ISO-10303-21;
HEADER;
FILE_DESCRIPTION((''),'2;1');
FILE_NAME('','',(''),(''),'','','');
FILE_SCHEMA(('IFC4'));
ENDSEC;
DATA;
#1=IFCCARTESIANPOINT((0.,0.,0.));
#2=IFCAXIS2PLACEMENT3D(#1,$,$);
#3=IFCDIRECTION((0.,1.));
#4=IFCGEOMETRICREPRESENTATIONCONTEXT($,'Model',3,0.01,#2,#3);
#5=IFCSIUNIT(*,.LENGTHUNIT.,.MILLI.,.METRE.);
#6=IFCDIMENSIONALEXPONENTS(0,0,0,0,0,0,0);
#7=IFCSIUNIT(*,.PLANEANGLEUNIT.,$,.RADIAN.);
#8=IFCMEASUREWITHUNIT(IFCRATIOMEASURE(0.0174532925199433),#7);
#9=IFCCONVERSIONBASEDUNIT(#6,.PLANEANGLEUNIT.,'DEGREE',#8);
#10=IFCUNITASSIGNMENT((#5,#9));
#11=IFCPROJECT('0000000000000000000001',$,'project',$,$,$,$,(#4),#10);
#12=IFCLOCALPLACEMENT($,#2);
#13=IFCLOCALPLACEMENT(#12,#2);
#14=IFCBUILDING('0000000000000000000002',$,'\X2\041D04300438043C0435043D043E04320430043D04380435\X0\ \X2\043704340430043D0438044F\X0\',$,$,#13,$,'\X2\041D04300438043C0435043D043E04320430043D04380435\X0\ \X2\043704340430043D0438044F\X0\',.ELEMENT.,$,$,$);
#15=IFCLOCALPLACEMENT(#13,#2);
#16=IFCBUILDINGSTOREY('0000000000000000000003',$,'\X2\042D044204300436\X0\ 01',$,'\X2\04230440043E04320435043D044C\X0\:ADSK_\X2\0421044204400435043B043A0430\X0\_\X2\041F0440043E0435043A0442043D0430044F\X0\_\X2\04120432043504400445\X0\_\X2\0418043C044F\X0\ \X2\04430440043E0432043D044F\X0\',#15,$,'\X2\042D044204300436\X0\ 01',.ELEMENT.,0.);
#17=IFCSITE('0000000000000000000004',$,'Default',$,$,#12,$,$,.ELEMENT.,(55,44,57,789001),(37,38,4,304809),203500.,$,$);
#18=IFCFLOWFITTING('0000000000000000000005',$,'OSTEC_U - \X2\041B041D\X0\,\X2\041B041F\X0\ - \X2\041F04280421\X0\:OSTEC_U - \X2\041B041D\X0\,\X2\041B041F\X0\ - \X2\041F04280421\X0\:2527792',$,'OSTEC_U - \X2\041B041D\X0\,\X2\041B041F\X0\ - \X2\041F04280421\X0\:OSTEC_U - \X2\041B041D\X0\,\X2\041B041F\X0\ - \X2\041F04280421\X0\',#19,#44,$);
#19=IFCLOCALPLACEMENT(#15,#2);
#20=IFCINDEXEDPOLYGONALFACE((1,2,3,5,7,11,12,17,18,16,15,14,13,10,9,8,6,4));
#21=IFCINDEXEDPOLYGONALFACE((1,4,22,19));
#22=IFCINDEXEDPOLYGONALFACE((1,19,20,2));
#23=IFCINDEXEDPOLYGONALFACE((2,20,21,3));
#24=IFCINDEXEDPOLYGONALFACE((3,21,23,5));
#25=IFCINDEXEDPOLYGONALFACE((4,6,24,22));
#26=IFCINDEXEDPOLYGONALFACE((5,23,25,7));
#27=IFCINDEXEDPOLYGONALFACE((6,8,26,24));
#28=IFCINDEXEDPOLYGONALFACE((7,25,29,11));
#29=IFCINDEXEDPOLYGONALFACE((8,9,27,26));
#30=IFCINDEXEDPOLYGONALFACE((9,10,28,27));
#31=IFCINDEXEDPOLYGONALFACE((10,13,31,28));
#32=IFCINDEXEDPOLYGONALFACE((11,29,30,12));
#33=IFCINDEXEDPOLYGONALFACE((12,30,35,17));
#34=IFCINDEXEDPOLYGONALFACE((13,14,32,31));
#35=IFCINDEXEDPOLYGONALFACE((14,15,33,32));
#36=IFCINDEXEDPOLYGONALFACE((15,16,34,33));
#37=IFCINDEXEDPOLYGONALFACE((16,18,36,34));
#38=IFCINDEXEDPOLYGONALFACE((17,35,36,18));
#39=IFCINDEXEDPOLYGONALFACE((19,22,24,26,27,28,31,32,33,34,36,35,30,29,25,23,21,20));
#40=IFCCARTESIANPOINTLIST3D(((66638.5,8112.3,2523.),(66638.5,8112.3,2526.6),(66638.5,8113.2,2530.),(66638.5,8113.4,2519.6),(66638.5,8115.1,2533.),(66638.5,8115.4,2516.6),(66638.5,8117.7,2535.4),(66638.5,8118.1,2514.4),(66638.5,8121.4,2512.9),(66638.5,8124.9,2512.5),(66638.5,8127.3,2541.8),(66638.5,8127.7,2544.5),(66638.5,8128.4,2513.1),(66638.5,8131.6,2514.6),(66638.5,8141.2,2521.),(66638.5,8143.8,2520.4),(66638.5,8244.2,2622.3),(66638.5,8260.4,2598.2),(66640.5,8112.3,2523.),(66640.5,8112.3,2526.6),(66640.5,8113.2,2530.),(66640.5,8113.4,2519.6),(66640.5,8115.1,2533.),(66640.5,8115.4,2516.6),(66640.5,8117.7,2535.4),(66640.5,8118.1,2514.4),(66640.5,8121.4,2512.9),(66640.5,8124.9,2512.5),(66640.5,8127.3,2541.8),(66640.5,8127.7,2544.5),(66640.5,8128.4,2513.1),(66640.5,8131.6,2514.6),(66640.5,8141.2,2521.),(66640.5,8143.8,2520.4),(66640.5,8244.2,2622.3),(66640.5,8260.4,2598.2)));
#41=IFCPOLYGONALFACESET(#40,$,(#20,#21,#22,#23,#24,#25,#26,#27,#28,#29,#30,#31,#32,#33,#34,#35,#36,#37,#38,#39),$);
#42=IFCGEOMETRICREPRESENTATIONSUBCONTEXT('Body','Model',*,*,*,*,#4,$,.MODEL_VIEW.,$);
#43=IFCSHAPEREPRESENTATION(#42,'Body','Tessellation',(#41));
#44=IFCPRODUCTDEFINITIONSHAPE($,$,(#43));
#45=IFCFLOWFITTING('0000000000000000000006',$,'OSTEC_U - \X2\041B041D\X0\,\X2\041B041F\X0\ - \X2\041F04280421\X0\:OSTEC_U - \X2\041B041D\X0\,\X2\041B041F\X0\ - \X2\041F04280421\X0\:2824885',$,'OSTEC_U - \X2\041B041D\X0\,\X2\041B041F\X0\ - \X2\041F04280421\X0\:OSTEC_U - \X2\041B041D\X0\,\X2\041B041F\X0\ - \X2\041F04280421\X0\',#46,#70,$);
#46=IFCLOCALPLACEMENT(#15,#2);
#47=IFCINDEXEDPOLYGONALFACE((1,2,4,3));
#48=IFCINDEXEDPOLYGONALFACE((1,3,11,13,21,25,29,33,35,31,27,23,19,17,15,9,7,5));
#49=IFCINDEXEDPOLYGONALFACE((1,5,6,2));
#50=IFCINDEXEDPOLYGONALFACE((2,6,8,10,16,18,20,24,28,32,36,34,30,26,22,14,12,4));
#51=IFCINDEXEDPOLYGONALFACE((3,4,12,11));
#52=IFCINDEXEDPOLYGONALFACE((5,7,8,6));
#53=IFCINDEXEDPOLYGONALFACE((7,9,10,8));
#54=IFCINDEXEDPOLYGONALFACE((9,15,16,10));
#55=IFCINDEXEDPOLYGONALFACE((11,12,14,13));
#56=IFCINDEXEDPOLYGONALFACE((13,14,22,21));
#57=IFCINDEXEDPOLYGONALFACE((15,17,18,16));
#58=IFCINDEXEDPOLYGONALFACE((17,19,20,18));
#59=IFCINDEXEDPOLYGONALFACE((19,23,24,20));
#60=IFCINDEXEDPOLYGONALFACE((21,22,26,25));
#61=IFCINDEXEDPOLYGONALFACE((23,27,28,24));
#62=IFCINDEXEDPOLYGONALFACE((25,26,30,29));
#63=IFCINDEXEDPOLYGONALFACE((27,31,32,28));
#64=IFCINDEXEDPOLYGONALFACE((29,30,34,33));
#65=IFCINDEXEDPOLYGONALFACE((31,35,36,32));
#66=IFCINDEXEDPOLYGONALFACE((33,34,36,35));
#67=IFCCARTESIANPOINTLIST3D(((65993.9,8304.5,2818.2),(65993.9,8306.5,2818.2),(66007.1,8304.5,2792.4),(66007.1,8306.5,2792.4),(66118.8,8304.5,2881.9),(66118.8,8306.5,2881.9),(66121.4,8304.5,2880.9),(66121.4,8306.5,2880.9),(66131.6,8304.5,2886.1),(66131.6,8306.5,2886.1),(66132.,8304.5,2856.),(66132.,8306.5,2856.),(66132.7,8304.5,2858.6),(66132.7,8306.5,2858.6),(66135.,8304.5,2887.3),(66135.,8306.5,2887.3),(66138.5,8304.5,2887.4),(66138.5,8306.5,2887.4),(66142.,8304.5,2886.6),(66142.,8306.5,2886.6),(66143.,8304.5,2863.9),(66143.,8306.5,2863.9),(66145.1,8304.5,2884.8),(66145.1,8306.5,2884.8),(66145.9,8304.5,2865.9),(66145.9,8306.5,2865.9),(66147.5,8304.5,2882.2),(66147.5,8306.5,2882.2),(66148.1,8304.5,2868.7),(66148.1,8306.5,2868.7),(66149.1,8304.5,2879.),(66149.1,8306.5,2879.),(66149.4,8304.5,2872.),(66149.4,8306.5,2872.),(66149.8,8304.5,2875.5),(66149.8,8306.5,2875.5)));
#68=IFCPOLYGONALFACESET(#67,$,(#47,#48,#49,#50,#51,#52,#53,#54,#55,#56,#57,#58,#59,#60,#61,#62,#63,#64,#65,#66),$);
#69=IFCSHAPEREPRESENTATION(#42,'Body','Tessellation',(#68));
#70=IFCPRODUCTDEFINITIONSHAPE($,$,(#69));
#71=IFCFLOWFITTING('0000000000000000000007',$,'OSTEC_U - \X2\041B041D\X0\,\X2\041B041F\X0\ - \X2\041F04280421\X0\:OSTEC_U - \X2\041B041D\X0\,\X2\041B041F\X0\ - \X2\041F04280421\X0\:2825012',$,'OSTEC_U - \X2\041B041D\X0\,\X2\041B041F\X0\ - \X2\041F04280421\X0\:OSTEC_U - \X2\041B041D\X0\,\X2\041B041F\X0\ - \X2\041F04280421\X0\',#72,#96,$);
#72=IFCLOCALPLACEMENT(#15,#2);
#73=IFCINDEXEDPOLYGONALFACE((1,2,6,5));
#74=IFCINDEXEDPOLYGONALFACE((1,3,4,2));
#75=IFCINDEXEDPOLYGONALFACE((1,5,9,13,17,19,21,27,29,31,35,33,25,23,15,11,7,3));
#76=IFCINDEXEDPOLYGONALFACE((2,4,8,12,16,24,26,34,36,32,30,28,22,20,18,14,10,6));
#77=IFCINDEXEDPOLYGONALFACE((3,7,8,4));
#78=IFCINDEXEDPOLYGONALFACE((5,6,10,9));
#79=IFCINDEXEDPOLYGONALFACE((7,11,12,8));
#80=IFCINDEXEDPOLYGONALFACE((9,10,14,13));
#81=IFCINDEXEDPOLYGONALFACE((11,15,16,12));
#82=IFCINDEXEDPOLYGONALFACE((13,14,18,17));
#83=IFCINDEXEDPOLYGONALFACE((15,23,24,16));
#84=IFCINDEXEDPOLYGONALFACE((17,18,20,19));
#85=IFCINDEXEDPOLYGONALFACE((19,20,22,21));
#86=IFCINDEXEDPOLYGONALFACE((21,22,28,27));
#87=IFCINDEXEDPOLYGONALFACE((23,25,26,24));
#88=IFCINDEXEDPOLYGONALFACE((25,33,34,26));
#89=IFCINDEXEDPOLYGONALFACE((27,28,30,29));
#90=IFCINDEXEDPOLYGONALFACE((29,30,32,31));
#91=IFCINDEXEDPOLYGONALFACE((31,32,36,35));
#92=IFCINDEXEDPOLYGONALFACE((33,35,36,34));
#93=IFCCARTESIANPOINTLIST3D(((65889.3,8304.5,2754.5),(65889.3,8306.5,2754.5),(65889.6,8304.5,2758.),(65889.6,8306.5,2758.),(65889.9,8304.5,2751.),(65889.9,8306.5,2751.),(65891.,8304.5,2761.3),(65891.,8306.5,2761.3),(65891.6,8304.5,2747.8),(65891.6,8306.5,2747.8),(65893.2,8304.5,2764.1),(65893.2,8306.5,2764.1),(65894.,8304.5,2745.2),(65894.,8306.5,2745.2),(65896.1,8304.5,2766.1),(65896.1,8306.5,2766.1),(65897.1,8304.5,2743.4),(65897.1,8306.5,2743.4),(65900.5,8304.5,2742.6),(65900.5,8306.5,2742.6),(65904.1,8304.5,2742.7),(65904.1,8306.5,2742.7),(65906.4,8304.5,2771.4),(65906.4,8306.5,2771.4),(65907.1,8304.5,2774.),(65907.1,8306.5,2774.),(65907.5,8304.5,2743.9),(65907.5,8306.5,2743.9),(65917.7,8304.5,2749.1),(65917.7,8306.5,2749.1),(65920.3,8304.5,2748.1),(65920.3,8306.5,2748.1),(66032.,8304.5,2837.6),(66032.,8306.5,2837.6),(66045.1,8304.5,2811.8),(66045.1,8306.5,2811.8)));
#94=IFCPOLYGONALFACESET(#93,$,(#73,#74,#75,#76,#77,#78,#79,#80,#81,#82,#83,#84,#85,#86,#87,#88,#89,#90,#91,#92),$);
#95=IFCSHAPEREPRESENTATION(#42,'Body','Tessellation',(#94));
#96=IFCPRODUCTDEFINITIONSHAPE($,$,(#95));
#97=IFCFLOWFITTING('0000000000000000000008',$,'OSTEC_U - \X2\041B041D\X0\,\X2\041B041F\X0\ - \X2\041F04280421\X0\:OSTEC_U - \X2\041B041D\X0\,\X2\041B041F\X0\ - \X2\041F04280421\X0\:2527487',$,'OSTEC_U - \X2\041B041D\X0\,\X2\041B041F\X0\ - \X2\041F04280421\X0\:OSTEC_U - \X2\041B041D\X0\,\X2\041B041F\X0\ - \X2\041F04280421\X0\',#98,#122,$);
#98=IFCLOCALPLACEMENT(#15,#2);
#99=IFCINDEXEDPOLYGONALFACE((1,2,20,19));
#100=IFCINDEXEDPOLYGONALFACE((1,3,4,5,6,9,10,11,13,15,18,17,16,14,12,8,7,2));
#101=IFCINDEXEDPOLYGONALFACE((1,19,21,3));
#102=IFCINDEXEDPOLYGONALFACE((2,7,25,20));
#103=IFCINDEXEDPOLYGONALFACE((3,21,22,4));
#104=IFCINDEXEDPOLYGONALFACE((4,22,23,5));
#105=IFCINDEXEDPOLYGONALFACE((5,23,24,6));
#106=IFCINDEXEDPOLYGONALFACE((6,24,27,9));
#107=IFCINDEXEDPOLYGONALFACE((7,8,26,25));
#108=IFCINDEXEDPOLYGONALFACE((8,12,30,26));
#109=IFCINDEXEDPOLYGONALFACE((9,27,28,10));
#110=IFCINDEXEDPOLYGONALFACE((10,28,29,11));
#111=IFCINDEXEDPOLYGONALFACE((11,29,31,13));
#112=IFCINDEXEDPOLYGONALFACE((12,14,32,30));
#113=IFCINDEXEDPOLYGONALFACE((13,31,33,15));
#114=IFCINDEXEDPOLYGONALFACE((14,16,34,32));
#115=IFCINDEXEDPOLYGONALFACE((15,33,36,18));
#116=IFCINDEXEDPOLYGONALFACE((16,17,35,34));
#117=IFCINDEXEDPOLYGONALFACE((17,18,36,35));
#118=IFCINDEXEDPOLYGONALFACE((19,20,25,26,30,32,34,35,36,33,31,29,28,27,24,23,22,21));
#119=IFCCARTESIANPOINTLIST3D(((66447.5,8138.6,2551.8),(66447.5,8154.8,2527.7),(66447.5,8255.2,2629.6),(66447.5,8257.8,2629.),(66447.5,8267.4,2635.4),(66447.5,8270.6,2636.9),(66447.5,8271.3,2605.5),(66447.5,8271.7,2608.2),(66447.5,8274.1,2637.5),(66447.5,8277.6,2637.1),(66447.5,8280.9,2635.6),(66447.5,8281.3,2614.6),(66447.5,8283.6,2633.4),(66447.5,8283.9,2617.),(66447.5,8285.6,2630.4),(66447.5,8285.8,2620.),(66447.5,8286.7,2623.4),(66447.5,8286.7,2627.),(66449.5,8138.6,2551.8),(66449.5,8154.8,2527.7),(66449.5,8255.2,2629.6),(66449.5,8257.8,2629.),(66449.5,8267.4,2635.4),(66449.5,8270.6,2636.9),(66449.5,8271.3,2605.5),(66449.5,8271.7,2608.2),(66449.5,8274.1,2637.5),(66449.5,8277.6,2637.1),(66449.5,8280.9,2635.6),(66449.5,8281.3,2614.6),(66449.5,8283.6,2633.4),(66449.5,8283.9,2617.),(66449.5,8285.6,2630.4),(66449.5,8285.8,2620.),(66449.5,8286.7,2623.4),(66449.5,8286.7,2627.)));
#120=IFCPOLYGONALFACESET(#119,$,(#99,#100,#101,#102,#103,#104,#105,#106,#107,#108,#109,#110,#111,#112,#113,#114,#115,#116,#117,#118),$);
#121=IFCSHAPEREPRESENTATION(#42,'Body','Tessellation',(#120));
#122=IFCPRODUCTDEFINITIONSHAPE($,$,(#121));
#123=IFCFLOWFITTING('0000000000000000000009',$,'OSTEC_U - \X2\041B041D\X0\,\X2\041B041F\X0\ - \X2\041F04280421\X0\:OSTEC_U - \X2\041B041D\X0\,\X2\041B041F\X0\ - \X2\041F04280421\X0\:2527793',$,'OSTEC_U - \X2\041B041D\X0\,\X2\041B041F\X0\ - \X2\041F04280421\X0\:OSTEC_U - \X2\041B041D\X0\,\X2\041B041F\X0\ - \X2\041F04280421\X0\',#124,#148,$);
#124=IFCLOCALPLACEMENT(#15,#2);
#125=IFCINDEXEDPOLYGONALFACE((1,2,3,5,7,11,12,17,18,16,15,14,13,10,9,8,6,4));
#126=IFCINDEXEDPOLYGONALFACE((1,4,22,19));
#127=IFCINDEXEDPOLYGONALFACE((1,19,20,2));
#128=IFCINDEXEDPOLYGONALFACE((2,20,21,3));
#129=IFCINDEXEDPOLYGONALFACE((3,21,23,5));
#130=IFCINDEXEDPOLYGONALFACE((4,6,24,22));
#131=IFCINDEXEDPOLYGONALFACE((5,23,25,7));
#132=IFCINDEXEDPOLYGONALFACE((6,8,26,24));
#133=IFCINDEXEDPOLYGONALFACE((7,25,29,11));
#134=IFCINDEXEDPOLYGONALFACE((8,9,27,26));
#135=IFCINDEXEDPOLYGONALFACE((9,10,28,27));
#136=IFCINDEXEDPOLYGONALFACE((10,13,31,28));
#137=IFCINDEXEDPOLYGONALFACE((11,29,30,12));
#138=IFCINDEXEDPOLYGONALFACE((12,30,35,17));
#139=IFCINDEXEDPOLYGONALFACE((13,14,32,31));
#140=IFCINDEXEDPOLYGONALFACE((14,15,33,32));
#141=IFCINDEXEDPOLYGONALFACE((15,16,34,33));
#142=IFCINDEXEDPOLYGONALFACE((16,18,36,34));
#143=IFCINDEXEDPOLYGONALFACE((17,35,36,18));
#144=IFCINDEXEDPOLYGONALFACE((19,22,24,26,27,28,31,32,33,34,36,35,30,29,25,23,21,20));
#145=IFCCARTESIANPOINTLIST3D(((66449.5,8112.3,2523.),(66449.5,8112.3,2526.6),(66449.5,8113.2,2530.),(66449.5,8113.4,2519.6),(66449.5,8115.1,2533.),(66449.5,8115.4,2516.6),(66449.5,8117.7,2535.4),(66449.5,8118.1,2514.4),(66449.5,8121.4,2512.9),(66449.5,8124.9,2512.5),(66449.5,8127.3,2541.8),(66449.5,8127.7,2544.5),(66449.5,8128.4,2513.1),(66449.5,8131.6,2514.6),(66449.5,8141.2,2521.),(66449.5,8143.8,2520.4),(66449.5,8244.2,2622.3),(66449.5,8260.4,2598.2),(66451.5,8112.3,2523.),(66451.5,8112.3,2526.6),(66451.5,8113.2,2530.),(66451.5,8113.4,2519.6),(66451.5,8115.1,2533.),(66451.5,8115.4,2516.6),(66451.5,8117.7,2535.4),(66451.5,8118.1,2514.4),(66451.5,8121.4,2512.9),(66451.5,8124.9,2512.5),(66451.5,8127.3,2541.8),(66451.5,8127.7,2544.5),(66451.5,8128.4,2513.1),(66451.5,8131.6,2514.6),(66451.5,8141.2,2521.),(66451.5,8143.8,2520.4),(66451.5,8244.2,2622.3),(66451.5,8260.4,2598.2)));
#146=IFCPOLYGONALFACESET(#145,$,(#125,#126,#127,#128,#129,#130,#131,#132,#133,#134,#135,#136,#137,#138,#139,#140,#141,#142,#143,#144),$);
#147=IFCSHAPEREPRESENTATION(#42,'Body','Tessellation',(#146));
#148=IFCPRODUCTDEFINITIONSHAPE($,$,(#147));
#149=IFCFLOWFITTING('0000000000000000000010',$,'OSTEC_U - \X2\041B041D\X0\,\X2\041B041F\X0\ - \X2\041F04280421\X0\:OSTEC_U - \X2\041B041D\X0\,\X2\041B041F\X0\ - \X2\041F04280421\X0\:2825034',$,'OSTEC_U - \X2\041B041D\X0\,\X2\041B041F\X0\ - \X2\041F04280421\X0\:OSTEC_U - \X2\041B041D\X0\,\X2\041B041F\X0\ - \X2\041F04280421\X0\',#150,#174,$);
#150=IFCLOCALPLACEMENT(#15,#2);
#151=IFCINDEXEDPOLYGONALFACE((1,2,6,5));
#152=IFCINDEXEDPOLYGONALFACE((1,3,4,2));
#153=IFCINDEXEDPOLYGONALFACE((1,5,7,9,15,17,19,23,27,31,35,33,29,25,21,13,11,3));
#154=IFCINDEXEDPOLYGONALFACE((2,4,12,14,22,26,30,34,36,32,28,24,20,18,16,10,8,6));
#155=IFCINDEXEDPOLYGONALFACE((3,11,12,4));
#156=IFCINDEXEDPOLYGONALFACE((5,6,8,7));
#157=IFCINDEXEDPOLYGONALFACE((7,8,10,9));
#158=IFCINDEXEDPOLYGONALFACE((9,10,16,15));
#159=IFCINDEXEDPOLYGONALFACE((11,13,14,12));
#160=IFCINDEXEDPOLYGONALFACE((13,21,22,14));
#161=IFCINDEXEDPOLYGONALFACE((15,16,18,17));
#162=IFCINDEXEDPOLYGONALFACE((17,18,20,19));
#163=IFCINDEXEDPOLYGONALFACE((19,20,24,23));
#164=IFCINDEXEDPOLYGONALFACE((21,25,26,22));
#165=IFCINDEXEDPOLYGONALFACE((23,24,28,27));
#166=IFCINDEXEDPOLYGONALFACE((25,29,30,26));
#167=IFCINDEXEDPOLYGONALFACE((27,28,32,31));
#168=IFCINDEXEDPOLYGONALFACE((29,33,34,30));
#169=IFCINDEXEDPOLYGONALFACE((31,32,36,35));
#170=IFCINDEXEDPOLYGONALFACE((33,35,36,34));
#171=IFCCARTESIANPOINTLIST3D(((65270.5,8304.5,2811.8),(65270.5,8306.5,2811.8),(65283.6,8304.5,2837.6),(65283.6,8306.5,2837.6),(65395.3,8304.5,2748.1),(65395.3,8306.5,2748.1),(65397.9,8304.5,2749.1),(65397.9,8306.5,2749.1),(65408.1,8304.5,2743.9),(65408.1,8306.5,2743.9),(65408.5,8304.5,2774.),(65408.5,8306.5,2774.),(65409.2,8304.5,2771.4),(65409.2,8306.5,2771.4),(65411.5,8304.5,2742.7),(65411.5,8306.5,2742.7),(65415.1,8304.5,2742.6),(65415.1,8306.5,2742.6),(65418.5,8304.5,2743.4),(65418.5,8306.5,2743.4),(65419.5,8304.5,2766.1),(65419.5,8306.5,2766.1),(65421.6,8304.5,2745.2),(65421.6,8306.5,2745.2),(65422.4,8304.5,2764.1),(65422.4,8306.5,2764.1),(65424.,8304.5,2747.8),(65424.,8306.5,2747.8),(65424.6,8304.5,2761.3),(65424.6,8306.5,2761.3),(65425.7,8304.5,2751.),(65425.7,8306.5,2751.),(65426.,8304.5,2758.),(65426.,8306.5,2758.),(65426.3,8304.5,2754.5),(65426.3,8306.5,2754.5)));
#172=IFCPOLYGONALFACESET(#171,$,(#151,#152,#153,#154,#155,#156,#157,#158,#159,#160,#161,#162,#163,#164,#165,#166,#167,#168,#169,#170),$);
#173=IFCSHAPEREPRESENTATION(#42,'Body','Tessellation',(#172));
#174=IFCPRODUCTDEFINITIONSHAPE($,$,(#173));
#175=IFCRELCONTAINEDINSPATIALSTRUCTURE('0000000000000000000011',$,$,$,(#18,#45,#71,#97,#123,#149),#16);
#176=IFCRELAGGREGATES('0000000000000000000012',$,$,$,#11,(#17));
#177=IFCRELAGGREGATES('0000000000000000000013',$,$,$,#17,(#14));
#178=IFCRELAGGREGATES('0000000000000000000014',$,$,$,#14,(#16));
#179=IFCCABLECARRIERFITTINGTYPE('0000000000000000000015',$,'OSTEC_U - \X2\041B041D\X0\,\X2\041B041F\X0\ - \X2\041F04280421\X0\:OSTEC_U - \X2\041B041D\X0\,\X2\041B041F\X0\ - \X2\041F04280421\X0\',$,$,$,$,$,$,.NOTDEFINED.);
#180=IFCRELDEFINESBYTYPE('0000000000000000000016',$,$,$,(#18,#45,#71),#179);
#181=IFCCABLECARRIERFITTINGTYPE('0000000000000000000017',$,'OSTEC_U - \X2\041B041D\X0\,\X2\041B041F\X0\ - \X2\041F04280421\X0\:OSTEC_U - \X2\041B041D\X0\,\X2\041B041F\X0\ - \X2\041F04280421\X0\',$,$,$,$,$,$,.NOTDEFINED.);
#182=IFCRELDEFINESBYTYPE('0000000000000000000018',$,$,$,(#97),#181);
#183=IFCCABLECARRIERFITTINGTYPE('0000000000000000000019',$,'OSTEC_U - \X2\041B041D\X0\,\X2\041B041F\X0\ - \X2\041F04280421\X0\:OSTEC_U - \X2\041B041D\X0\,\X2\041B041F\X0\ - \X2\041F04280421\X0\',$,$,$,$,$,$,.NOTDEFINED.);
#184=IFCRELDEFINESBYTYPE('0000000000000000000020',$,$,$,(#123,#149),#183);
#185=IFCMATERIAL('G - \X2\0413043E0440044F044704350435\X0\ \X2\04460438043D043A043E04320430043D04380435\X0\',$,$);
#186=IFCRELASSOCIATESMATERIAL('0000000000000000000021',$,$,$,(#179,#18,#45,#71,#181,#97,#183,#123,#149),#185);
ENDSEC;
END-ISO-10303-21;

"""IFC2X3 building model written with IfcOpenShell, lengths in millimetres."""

from ifc_helpers import new_model, entity, si_unit, converted_unit, direction, frame, frame_2d, origin, place, context, subcontext, project, spatial, polyline, circle_curve, parameter, trimmed, segment, composite_curve, outline, extrude, source, transform, mapped, material, type_object, type_shapes, element, save


model = new_model("IFC2X3")

# Units and contexts
model_context = context("Model", 3, precision=0.01, world=origin(), true_north=direction((0.0, 1.0)))
body_context = subcontext(model_context, "Body", "Model", "MODEL_VIEW")
ifc_project = project(units=[si_unit("LENGTHUNIT", "METRE", prefix="MILLI"), converted_unit("PLANEANGLEUNIT", "DEGREE", entity("IfcRatioMeasure", 0.0174532925199433), si_unit("PLANEANGLEUNIT", "RADIAN"), dimensions=[0, 0, 0, 0, 0, 0, 0])], contexts=[model_context])

# Site, building, storey
site_placement = place(None, origin())
site = spatial("IfcSite", under=ifc_project, at=site_placement, Name="Default", CompositionType="ELEMENT", RefLatitude=(55, 44, 57, 789001), RefLongitude=(37, 38, 4, 304809), RefElevation=203500.0)
building_placement = place(site_placement, origin())
building = spatial("IfcBuilding", under=site, at=building_placement, Name="Наименование здания", LongName="Наименование здания", CompositionType="ELEMENT")
storey_placement = place(building_placement, origin())
storey = spatial("IfcBuildingStorey", under=building, at=storey_placement, Name="Этаж 01", ObjectType="Уровень:ADSK_Стрелка_Проектная_Вверх_Имя уровня", LongName="Этаж 01", CompositionType="ELEMENT", Elevation=0.0)

# Flow fittings
ifc_material = material(Name="G - Горячее цинкование")
shared_shape_1 = source(origin(), body_context, "Body", "SweptSolid", [
    extrude(outline(composite_curve([segment(trimmed(circle_curve(frame_2d((-44.6, 0.0), x_axis=(1.0, 0.0)), 12.5), [parameter(90.0)], [parameter(270.0)], True, "PARAMETER"), True, "CONTINUOUS"), segment(polyline([(-44.6, -12.5), (-33.1, -12.5)]), True, "CONTINUOUS"), segment(polyline([(-33.1, -12.5), (-31.2, -14.5)]), True, "CONTINUOUS"), segment(polyline([(-31.2, -14.5), (108.9, -14.5)]), True, "CONTINUOUS"), segment(polyline([(108.9, -14.5), (108.9, 14.5)]), True, "CONTINUOUS"), segment(polyline([(108.9, 14.5), (-31.2, 14.5)]), True, "CONTINUOUS"), segment(polyline([(-31.2, 14.5), (-33.1, 12.5)]), True, "CONTINUOUS"), segment(polyline([(-33.1, 12.5), (-44.6, 12.5)]), True, "CONTINUOUS")], self_intersect=False)), frame((44.6, 0.0, 0.0), z_axis=(0.0, 0.0, -1.0), x_axis=(1.0, 0.0, 0.0)), (0.0, 0.0, -1.0), 2.0),
])
cable_carrier_fitting_type_1 = type_object("IfcCableCarrierFittingType", Name="OSTEC_U - ЛН,ЛП - ПШС:OSTEC_U - ЛН,ЛП - ПШС", PredefinedType="NOTDEFINED", material=ifc_material)
type_shapes(cable_carrier_fitting_type_1, [shared_shape_1])
for number, where, z_axis, x_axis, name in (
    (1, (66638.5, 8124.7, 2525.0), (1.0, 0.0, 0.0), (0.0, 0.831467, 0.555575), "OSTEC_U - ЛН,ЛП - ПШС:OSTEC_U - ЛН,ЛП - ПШС:2527792"),
    (2, (66137.3, 8306.5, 2875.0), (0.0, -1.0, 0.0), (-0.891007, 0.0, -0.45399), "OSTEC_U - ЛН,ЛП - ПШС:OSTEC_U - ЛН,ЛП - ПШС:2824885"),
    (3, (65901.8, 8306.5, 2755.0), (0.0, -1.0, 0.0), (0.891007, 0.0, 0.45399), "OSTEC_U - ЛН,ЛП - ПШС:OSTEC_U - ЛН,ЛП - ПШС:2825012"),
):
    element("IfcFlowFitting", number, at=place(storey_placement, frame(where, z_axis=z_axis, x_axis=x_axis)), inside=storey, type_object=cable_carrier_fitting_type_1, material=ifc_material, Name=name, ObjectType="OSTEC_U - ЛН,ЛП - ПШС:OSTEC_U - ЛН,ЛП - ПШС", context=body_context, shape_type="MappedRepresentation", body=[
        mapped(shared_shape_1, transform((0.0, 0.0, 0.0), scale=1.0)),
    ])
cable_carrier_fitting_type_2 = type_object("IfcCableCarrierFittingType", Name="OSTEC_U - ЛН,ЛП - ПШС:OSTEC_U - ЛН,ЛП - ПШС", PredefinedType="NOTDEFINED", material=ifc_material)
shared_shape_2 = source(origin(), body_context, "Body", "SweptSolid", [
    extrude(outline(composite_curve([segment(trimmed(circle_curve(frame_2d((-44.6, 0.0), x_axis=(1.0, 0.0)), 12.5), [parameter(90.0)], [parameter(270.0)], True, "PARAMETER"), True, "CONTINUOUS"), segment(polyline([(-44.6, -12.5), (-33.1, -12.5)]), True, "CONTINUOUS"), segment(polyline([(-33.1, -12.5), (-31.2, -14.5)]), True, "CONTINUOUS"), segment(polyline([(-31.2, -14.5), (108.9, -14.5)]), True, "CONTINUOUS"), segment(polyline([(108.9, -14.5), (108.9, 14.5)]), True, "CONTINUOUS"), segment(polyline([(108.9, 14.5), (-31.2, 14.5)]), True, "CONTINUOUS"), segment(polyline([(-31.2, 14.5), (-33.1, 12.5)]), True, "CONTINUOUS"), segment(polyline([(-33.1, 12.5), (-44.6, 12.5)]), True, "CONTINUOUS")], self_intersect=False)), frame((44.6, 0.0, 0.0)), (0.0, 0.0, 1.0), 2.0),
])
type_shapes(cable_carrier_fitting_type_2, [shared_shape_2])
flow_fitting_1_placement = place(storey_placement, frame((66449.5, 8274.3, 2625.0), z_axis=(-1.0, 0.0, 0.0), x_axis=(0.0, -0.831467, -0.555575)))
element("IfcFlowFitting", 4, at=flow_fitting_1_placement, inside=storey, type_object=cable_carrier_fitting_type_2, material=ifc_material, Name="OSTEC_U - ЛН,ЛП - ПШС:OSTEC_U - ЛН,ЛП - ПШС:2527487", ObjectType="OSTEC_U - ЛН,ЛП - ПШС:OSTEC_U - ЛН,ЛП - ПШС", context=body_context, shape_type="MappedRepresentation", body=[
    mapped(shared_shape_2, transform((0.0, 0.0, 0.0), scale=1.0)),
])
cable_carrier_fitting_type_3 = type_object("IfcCableCarrierFittingType", Name="OSTEC_U - ЛН,ЛП - ПШС:OSTEC_U - ЛН,ЛП - ПШС", PredefinedType="NOTDEFINED", material=ifc_material)
type_shapes(cable_carrier_fitting_type_3, [shared_shape_2])
flow_fitting_2_placement = place(storey_placement, frame((66451.5, 8124.7, 2525.0), z_axis=(-1.0, 0.0, 0.0), x_axis=(0.0, 0.831467, 0.555575)))
element("IfcFlowFitting", 5, at=flow_fitting_2_placement, inside=storey, type_object=cable_carrier_fitting_type_3, material=ifc_material, Name="OSTEC_U - ЛН,ЛП - ПШС:OSTEC_U - ЛН,ЛП - ПШС:2527793", ObjectType="OSTEC_U - ЛН,ЛП - ПШС:OSTEC_U - ЛН,ЛП - ПШС", context=body_context, shape_type="MappedRepresentation", body=[
    mapped(shared_shape_2, transform((0.0, 0.0, 0.0), scale=1.0)),
])
for number, where, z_axis, x_axis, name in (
    (6, (65413.8, 8306.5, 2755.0), (0.0, -1.0, 0.0), (-0.891007, 0.0, 0.45399), "OSTEC_U - ЛН,ЛП - ПШС:OSTEC_U - ЛН,ЛП - ПШС:2825034"),
):
    element("IfcFlowFitting", number, at=place(storey_placement, frame(where, z_axis=z_axis, x_axis=x_axis)), inside=storey, type_object=cable_carrier_fitting_type_3, material=ifc_material, Name=name, ObjectType="OSTEC_U - ЛН,ЛП - ПШС:OSTEC_U - ЛН,ЛП - ПШС", context=body_context, shape_type="MappedRepresentation", body=[
        mapped(shared_shape_2, transform((0.0, 0.0, 0.0), scale=1.0)),
    ])

save(model, "model.ifc")
